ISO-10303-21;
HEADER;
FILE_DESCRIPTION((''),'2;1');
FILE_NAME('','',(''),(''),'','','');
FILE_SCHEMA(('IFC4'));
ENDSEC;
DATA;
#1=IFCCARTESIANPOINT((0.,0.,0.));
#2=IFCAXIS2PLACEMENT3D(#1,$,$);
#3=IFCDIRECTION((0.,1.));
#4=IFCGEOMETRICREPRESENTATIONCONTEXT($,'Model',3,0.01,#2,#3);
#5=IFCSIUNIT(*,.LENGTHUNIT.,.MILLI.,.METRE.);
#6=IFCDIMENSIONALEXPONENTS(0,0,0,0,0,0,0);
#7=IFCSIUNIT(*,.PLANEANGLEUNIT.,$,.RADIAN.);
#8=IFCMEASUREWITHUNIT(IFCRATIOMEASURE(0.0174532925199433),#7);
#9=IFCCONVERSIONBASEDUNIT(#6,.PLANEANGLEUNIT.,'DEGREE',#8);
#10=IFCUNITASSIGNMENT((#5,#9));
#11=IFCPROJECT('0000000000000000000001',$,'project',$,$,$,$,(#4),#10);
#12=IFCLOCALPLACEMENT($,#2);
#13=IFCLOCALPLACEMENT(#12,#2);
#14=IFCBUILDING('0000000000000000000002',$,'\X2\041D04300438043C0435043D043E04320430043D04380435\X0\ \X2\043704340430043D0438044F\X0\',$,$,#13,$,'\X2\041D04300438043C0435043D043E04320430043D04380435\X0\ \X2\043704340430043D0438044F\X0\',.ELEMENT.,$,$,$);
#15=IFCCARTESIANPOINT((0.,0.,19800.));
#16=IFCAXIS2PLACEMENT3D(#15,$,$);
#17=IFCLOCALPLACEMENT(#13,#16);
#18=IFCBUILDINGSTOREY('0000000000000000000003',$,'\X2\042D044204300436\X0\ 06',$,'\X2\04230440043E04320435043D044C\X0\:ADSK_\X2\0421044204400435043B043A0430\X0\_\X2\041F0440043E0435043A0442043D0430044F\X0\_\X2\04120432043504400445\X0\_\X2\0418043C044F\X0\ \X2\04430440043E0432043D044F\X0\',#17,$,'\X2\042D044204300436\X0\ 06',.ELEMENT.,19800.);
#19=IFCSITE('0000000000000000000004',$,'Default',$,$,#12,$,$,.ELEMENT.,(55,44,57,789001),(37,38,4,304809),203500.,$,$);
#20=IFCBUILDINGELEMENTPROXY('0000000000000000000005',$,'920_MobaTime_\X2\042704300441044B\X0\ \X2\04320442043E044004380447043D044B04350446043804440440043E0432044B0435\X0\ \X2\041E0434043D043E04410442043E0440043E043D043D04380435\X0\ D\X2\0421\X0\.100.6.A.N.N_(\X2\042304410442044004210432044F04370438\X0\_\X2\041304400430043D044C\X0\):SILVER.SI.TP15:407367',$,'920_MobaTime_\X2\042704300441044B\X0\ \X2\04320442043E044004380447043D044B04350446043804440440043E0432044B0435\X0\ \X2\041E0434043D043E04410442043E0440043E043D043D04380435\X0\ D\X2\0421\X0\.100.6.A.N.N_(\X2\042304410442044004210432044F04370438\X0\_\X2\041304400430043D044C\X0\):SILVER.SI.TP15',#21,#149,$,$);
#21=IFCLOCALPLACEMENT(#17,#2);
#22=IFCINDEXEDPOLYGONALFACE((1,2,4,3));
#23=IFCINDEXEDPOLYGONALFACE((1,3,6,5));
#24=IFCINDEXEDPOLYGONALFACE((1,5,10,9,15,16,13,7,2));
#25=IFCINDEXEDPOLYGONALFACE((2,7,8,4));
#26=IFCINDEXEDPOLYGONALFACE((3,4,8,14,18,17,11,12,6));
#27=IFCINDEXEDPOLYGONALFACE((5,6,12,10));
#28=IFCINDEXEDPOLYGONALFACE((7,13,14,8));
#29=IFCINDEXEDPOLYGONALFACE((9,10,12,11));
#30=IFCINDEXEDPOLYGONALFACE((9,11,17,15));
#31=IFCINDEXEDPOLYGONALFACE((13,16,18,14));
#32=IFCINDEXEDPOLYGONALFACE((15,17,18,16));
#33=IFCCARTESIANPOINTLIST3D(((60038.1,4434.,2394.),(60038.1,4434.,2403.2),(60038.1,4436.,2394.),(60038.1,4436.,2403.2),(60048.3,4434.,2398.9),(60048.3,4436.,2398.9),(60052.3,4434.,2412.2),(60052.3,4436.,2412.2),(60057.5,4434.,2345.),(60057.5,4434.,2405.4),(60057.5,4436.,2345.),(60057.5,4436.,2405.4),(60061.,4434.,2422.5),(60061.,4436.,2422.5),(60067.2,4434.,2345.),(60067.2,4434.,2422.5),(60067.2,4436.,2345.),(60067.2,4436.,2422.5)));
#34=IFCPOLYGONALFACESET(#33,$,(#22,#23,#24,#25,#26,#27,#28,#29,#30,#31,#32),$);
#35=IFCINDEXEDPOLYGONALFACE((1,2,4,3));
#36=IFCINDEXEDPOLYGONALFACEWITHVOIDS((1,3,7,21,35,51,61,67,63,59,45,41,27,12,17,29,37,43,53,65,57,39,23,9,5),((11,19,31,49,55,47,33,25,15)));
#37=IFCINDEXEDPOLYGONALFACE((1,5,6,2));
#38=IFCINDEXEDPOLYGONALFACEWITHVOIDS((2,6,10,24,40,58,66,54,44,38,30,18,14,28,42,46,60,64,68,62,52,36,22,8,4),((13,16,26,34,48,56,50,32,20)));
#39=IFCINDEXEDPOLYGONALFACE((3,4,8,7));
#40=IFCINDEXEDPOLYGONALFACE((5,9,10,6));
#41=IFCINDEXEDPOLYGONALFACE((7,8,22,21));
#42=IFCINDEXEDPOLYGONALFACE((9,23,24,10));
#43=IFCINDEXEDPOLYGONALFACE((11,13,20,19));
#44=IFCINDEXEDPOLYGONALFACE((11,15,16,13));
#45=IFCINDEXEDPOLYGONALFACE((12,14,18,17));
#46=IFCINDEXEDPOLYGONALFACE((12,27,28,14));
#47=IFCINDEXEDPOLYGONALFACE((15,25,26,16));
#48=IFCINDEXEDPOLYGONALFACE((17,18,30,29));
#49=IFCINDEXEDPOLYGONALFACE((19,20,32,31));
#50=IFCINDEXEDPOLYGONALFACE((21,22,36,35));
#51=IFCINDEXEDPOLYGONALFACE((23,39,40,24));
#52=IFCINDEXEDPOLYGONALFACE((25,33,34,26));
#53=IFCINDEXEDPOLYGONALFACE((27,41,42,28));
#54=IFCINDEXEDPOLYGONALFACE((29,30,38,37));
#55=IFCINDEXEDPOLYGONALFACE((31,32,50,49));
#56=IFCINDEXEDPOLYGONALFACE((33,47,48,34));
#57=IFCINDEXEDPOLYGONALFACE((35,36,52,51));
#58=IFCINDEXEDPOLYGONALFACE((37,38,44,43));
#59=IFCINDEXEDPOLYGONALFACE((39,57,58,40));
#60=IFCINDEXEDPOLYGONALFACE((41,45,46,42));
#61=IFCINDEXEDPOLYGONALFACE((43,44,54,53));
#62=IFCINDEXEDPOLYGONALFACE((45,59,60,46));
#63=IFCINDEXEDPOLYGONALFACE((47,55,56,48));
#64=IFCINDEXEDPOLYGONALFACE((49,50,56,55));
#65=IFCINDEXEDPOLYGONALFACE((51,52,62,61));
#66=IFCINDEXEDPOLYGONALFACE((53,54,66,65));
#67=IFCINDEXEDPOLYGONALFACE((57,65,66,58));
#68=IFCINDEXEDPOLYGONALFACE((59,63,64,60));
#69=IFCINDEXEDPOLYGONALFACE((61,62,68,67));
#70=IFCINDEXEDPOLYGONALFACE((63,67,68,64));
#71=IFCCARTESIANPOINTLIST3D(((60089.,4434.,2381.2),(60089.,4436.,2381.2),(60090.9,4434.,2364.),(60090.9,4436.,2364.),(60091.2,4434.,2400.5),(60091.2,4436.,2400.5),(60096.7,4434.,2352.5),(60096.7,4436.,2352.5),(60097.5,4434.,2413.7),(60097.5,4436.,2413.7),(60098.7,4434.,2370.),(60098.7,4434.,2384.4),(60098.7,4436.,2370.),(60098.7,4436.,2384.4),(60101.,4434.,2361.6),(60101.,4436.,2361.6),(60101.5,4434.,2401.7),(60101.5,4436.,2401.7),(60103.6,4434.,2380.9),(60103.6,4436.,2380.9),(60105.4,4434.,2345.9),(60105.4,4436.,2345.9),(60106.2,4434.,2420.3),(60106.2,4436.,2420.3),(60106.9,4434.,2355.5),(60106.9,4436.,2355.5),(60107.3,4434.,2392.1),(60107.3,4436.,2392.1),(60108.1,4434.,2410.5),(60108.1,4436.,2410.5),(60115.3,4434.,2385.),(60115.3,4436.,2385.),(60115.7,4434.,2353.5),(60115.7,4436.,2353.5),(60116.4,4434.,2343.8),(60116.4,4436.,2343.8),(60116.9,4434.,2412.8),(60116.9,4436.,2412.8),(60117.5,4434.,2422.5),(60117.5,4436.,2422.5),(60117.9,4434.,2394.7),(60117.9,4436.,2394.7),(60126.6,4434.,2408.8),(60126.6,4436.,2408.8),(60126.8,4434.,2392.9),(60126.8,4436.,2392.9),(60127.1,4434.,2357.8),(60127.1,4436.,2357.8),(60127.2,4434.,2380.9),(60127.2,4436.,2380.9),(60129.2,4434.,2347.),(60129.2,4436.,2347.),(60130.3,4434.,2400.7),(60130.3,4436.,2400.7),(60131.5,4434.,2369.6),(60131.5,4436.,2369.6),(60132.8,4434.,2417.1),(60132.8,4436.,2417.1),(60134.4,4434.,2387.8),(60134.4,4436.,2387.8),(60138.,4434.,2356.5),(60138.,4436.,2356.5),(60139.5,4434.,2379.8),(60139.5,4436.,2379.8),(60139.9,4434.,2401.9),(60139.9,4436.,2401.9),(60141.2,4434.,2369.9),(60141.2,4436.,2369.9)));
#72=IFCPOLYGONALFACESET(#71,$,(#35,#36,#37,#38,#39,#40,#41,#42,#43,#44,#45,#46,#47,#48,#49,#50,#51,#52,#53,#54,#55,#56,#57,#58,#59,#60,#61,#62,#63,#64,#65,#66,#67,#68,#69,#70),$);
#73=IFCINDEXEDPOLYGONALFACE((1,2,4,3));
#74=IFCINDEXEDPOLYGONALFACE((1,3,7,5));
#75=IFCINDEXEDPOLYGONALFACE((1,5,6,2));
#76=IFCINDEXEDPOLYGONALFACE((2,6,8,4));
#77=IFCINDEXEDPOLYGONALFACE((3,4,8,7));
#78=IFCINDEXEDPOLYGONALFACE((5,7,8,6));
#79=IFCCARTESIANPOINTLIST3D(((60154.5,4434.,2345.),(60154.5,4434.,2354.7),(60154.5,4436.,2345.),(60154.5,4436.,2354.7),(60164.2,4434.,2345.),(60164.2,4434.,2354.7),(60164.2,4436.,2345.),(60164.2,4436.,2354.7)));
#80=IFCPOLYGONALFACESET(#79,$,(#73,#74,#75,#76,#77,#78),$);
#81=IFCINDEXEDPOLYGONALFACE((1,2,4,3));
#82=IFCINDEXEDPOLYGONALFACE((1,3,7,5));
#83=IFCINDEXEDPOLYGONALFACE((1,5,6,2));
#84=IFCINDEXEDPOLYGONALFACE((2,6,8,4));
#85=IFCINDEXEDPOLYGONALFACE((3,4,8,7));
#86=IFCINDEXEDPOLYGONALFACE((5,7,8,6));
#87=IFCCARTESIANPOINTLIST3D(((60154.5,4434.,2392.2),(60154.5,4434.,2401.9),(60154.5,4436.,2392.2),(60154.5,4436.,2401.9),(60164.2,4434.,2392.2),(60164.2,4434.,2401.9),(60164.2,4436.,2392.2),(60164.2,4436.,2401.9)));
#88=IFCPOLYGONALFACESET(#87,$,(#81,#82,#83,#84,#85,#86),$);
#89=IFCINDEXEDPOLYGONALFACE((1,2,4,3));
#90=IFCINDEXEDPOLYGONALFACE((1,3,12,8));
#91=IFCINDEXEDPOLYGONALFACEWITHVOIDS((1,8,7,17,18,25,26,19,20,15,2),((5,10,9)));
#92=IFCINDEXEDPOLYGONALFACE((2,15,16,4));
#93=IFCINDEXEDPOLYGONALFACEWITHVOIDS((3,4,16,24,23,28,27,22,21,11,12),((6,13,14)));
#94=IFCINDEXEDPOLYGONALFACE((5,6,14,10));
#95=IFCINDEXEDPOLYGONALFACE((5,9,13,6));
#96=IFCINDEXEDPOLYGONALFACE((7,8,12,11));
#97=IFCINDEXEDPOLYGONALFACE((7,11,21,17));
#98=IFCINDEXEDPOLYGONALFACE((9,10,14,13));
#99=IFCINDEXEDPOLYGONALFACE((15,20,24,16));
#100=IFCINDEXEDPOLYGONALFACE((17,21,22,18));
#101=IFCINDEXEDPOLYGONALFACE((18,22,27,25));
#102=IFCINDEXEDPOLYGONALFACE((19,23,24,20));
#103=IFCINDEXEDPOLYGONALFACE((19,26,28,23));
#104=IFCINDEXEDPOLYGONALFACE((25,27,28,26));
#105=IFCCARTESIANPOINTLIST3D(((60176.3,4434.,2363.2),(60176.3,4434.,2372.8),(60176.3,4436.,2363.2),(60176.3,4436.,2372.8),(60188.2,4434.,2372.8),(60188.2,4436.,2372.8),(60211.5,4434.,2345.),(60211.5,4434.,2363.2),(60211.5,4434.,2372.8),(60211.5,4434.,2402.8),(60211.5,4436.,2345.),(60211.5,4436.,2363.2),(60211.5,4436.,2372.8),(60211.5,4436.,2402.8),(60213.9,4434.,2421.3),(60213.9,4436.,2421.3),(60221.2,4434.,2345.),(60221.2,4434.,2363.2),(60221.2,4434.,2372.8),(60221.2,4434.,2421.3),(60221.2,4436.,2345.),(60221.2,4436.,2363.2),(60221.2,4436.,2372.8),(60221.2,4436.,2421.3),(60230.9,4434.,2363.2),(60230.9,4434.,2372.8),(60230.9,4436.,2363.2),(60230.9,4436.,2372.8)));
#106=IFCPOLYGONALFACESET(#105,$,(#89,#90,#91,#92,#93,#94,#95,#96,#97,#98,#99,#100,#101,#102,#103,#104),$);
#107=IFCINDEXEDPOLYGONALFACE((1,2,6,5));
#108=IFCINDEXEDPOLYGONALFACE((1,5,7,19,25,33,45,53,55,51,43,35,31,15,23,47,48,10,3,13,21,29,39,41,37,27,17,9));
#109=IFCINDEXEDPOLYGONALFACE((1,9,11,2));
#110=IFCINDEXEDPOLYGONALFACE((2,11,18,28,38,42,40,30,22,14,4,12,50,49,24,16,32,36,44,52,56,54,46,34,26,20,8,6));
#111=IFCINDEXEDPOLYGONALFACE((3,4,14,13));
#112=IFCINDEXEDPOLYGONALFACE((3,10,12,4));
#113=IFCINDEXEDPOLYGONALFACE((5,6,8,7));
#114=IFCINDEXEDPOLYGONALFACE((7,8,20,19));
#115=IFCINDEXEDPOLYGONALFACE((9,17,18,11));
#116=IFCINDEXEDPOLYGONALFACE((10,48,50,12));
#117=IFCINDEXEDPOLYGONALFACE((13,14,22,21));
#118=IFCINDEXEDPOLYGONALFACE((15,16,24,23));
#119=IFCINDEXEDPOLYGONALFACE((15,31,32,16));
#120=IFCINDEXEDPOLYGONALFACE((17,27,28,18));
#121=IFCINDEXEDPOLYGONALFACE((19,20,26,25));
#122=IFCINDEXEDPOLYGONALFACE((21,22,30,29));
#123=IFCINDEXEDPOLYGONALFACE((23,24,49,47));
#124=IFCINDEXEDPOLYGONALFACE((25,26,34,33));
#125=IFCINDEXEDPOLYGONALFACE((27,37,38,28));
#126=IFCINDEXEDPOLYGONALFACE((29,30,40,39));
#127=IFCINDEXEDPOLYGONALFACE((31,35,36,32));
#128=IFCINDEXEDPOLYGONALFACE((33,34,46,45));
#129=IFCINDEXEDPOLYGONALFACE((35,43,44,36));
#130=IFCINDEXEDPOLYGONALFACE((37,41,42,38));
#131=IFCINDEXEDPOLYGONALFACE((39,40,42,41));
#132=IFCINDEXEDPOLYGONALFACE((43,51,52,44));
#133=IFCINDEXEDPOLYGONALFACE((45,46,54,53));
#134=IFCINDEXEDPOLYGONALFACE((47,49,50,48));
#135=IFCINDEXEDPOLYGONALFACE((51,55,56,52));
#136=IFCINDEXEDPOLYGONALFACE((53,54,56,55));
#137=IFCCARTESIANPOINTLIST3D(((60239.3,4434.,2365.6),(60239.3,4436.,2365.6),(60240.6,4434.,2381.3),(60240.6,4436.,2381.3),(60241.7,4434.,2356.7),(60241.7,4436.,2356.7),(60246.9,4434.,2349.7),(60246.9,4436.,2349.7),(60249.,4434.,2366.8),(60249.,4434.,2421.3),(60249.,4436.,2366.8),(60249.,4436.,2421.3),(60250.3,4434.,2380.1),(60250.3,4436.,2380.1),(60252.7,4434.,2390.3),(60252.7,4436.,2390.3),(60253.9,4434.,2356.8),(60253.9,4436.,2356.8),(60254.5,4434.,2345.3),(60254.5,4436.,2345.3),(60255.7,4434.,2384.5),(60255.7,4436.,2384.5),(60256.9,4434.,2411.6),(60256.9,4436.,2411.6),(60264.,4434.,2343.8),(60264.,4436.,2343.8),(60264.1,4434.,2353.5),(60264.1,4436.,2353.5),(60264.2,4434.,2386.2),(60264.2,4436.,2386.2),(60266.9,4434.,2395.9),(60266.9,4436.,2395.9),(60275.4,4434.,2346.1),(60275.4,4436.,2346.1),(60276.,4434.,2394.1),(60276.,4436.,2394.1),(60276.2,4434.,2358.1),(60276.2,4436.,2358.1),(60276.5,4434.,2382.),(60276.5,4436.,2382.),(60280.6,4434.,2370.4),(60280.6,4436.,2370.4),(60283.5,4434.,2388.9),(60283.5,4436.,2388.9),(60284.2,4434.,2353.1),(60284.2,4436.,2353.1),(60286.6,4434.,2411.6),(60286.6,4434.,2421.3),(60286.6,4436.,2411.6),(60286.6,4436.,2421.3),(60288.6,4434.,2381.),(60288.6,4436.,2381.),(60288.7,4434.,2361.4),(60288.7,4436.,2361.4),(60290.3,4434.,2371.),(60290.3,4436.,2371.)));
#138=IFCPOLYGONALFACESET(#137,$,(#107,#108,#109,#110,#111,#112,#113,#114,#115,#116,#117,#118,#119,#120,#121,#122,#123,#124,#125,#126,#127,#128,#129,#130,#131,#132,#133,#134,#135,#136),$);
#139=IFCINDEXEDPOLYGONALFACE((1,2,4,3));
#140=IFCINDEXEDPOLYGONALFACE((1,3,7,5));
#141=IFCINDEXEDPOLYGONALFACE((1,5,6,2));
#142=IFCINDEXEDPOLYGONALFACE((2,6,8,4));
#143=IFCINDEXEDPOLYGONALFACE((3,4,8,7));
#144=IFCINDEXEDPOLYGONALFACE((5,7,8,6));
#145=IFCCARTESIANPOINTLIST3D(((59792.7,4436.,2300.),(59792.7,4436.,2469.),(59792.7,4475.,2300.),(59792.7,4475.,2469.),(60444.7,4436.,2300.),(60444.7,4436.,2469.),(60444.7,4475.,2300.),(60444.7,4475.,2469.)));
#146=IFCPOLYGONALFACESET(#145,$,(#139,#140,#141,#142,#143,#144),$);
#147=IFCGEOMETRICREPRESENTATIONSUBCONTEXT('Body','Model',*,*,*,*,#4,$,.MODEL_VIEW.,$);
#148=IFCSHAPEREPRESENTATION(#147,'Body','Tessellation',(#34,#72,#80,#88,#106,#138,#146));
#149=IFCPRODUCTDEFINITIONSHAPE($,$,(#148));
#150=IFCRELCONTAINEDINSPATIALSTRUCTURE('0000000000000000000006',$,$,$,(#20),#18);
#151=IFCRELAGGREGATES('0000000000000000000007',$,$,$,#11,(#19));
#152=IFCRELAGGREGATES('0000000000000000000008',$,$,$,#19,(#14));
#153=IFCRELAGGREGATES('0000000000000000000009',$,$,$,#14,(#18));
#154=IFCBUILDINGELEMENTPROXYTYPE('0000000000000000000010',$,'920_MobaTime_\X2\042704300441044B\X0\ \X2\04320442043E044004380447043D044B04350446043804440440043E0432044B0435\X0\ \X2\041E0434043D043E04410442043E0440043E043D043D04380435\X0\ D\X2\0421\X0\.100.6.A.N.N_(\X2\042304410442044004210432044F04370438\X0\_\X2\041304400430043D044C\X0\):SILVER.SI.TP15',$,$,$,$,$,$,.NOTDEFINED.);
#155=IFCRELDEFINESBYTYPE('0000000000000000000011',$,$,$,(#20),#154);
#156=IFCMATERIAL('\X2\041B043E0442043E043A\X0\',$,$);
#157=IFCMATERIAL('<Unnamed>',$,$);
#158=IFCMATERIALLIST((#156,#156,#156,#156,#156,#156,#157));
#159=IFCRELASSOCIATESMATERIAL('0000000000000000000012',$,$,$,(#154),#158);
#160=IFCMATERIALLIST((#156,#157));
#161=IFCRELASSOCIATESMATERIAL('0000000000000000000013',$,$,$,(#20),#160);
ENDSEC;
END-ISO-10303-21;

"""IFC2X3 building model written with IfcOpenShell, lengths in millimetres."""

from ifc_helpers import new_model, entity, si_unit, converted_unit, direction, frame, origin, origin_2d_with_axis, place, context, subcontext, project, spatial, polyline, rectangle, outline, extrude, source, transform, mapped, material, material_list, type_object, type_shapes, element, save


model = new_model("IFC2X3")

# Units and contexts
model_context = context("Model", 3, precision=0.01, world=origin(), true_north=direction((0.0, 1.0)))
body_context = subcontext(model_context, "Body", "Model", "MODEL_VIEW")
ifc_project = project(units=[si_unit("LENGTHUNIT", "METRE", prefix="MILLI"), converted_unit("PLANEANGLEUNIT", "DEGREE", entity("IfcRatioMeasure", 0.0174532925199433), si_unit("PLANEANGLEUNIT", "RADIAN"), dimensions=[0, 0, 0, 0, 0, 0, 0])], contexts=[model_context])

# Site, building, storey
site_placement = place(None, frame((0.0, 0.0, 0.0)))
site = spatial("IfcSite", under=ifc_project, at=site_placement, Name="Default", CompositionType="ELEMENT", RefLatitude=(55, 44, 57, 789001), RefLongitude=(37, 38, 4, 304809), RefElevation=203500.0)
building_placement = place(site_placement, origin())
building = spatial("IfcBuilding", under=site, at=building_placement, Name="Наименование здания", LongName="Наименование здания", CompositionType="ELEMENT")
storey_placement = place(building_placement, frame((0.0, 0.0, 19800.0)))
storey = spatial("IfcBuildingStorey", under=building, at=storey_placement, Name="Этаж 06", ObjectType="Уровень:ADSK_Стрелка_Проектная_Вверх_Имя уровня", LongName="Этаж 06", CompositionType="ELEMENT", Elevation=19800.0)

# Building element proxy
ifc_material_1 = material(Name="Лоток")
ifc_material_2 = material(Name="<Unnamed>")
ifc_material_list_1 = material_list([ifc_material_1, ifc_material_1, ifc_material_1, ifc_material_1, ifc_material_1, ifc_material_1, ifc_material_2])
building_element_proxy_type_1 = type_object("IfcBuildingElementProxyType", Name="920_MobaTime_Часы вторичныецифровые Односторонние DС.100.6.A.N.N_(УстрСвязи_Грань):SILVER.SI.TP15", PredefinedType="NOTDEFINED", material=ifc_material_list_1)
shared_shape_1 = source(origin(), body_context, "Body", "SweptSolid", [
    extrude(outline(polyline([(-49.3, -13.1), (28.2, -13.1), (28.2, -6.8), (17.9, 1.8), (8.9, 16.0), (-0.3, 16.0), (4.6, 5.8), (11.1, -3.4), (-49.3, -3.4), (-49.3, -13.1)])), frame((-64.6, 9.8, 39.0), z_axis=(0.0, 0.0, 1.0), x_axis=(0.0, 1.0, 0.0)), (0.0, 0.0, 1.0), 2.0),
    extrude(outline(polyline([(2.2, -27.6), (19.0, -27.6), (30.5, -16.1), (33.3, -4.9), (31.0, 5.8), (21.8, 17.2), (5.2, 27.3), (-11.1, 33.0), (-24.0, 32.7), (-33.6, 27.6), (-40.3, 18.6), (-42.8, 5.7), (-38.0, -6.3), (-27.2, -15.0), (-17.5, -17.7), (-8.2, -16.4), (-0.3, -11.9), (5.1, -4.5), (7.3, 6.2), (4.0, 17.2), (18.5, 7.3), (23.6, -2.4), (22.0, -11.4), (14.2, -18.4), (5.3, -18.3), (2.2, -27.6)]), holes=[polyline([(-9.0, 23.3), (-1.3, 14.4), (-2.6, 2.0), (-11.4, -7.0), (-23.4, -6.1), (-32.2, 2.9), (-31.2, 15.1), (-25.6, 22.1), (-17.5, 24.9), (-9.0, 23.3)])]), frame((-2.7, 3.6, 39.0), z_axis=(0.0, 0.0, 1.0), x_axis=(-0.427649, 0.903945, 0.0)), (0.0, 0.0, 1.0), 2.0),
    extrude(rectangle(XDim=9.7, YDim=9.7, at=origin_2d_with_axis()), frame((40.6, -34.7, 39.0)), (0.0, 0.0, 1.0), 2.0),
    extrude(rectangle(XDim=9.7, YDim=9.7, at=origin_2d_with_axis()), frame((40.6, 12.6, 39.0)), (0.0, 0.0, 1.0), 2.0),
    extrude(outline(polyline([(-0.9, -28.1), (8.8, -28.1), (8.8, -9.9), (18.5, -9.9), (18.5, -0.2), (8.8, -0.2), (8.8, 48.3), (1.5, 48.3), (-36.0, -0.2), (-36.0, -9.9), (-0.9, -9.9), (-0.9, -28.1)]), holes=[polyline([(-0.9, -0.2), (-24.1, -0.2), (-0.9, 29.7), (-0.9, -0.2)])]), frame((93.6, -11.4, 39.0)), (0.0, 0.0, 1.0), 2.0),
    extrude(outline(polyline([(3.3, -28.3), (12.5, -28.3), (20.5, -25.0), (26.8, -18.8), (30.7, -10.0), (31.4, 1.6), (26.9, 11.8), (20.1, 18.4), (11.1, 22.3), (1.0, 23.3), (-7.9, 20.4), (-14.9, 14.5), (-18.9, 6.2), (-17.1, -9.0), (-36.7, 0.5), (-29.1, 29.3), (-38.5, 31.7), (-48.1, -4.6), (-11.6, -23.0), (-8.0, -14.0), (-10.8, -7.6), (-10.2, 1.1), (-3.0, 11.8), (9.2, 12.8), (20.0, 5.4), (21.3, -7.5), (15.5, -16.4), (4.6, -18.6), (3.3, -28.3)])), frame((147.1, -8.5, 39.0), z_axis=(0.0, 0.0, 1.0), x_axis=(0.256974, -0.966418, 0.0)), (0.0, 0.0, 1.0), 2.0),
    extrude(rectangle(XDim=652.0, YDim=169.0, at=origin_2d_with_axis()), frame((0.0, 0.0, 0.0), z_axis=(0.0, 0.0, 1.0), x_axis=(-1.0, 0.0, 0.0)), (0.0, 0.0, 1.0), 39.0),
])
type_shapes(building_element_proxy_type_1, [shared_shape_1])
ifc_material_list_2 = material_list([ifc_material_1, ifc_material_2])
proxy_1_placement = place(storey_placement, frame((60118.7, 4475.0, 2384.5), z_axis=(0.0, -1.0, 0.0), x_axis=(1.0, 0.0, 0.0)))
element("IfcBuildingElementProxy", 1, at=proxy_1_placement, inside=storey, type_object=building_element_proxy_type_1, material=ifc_material_list_2, Name="920_MobaTime_Часы вторичныецифровые Односторонние DС.100.6.A.N.N_(УстрСвязи_Грань):SILVER.SI.TP15:407367", ObjectType="920_MobaTime_Часы вторичныецифровые Односторонние DС.100.6.A.N.N_(УстрСвязи_Грань):SILVER.SI.TP15", context=body_context, shape_type="MappedRepresentation", body=[
    mapped(shared_shape_1, transform((0.0, 0.0, 0.0), scale=1.0)),
])

save(model, "model.ifc")
